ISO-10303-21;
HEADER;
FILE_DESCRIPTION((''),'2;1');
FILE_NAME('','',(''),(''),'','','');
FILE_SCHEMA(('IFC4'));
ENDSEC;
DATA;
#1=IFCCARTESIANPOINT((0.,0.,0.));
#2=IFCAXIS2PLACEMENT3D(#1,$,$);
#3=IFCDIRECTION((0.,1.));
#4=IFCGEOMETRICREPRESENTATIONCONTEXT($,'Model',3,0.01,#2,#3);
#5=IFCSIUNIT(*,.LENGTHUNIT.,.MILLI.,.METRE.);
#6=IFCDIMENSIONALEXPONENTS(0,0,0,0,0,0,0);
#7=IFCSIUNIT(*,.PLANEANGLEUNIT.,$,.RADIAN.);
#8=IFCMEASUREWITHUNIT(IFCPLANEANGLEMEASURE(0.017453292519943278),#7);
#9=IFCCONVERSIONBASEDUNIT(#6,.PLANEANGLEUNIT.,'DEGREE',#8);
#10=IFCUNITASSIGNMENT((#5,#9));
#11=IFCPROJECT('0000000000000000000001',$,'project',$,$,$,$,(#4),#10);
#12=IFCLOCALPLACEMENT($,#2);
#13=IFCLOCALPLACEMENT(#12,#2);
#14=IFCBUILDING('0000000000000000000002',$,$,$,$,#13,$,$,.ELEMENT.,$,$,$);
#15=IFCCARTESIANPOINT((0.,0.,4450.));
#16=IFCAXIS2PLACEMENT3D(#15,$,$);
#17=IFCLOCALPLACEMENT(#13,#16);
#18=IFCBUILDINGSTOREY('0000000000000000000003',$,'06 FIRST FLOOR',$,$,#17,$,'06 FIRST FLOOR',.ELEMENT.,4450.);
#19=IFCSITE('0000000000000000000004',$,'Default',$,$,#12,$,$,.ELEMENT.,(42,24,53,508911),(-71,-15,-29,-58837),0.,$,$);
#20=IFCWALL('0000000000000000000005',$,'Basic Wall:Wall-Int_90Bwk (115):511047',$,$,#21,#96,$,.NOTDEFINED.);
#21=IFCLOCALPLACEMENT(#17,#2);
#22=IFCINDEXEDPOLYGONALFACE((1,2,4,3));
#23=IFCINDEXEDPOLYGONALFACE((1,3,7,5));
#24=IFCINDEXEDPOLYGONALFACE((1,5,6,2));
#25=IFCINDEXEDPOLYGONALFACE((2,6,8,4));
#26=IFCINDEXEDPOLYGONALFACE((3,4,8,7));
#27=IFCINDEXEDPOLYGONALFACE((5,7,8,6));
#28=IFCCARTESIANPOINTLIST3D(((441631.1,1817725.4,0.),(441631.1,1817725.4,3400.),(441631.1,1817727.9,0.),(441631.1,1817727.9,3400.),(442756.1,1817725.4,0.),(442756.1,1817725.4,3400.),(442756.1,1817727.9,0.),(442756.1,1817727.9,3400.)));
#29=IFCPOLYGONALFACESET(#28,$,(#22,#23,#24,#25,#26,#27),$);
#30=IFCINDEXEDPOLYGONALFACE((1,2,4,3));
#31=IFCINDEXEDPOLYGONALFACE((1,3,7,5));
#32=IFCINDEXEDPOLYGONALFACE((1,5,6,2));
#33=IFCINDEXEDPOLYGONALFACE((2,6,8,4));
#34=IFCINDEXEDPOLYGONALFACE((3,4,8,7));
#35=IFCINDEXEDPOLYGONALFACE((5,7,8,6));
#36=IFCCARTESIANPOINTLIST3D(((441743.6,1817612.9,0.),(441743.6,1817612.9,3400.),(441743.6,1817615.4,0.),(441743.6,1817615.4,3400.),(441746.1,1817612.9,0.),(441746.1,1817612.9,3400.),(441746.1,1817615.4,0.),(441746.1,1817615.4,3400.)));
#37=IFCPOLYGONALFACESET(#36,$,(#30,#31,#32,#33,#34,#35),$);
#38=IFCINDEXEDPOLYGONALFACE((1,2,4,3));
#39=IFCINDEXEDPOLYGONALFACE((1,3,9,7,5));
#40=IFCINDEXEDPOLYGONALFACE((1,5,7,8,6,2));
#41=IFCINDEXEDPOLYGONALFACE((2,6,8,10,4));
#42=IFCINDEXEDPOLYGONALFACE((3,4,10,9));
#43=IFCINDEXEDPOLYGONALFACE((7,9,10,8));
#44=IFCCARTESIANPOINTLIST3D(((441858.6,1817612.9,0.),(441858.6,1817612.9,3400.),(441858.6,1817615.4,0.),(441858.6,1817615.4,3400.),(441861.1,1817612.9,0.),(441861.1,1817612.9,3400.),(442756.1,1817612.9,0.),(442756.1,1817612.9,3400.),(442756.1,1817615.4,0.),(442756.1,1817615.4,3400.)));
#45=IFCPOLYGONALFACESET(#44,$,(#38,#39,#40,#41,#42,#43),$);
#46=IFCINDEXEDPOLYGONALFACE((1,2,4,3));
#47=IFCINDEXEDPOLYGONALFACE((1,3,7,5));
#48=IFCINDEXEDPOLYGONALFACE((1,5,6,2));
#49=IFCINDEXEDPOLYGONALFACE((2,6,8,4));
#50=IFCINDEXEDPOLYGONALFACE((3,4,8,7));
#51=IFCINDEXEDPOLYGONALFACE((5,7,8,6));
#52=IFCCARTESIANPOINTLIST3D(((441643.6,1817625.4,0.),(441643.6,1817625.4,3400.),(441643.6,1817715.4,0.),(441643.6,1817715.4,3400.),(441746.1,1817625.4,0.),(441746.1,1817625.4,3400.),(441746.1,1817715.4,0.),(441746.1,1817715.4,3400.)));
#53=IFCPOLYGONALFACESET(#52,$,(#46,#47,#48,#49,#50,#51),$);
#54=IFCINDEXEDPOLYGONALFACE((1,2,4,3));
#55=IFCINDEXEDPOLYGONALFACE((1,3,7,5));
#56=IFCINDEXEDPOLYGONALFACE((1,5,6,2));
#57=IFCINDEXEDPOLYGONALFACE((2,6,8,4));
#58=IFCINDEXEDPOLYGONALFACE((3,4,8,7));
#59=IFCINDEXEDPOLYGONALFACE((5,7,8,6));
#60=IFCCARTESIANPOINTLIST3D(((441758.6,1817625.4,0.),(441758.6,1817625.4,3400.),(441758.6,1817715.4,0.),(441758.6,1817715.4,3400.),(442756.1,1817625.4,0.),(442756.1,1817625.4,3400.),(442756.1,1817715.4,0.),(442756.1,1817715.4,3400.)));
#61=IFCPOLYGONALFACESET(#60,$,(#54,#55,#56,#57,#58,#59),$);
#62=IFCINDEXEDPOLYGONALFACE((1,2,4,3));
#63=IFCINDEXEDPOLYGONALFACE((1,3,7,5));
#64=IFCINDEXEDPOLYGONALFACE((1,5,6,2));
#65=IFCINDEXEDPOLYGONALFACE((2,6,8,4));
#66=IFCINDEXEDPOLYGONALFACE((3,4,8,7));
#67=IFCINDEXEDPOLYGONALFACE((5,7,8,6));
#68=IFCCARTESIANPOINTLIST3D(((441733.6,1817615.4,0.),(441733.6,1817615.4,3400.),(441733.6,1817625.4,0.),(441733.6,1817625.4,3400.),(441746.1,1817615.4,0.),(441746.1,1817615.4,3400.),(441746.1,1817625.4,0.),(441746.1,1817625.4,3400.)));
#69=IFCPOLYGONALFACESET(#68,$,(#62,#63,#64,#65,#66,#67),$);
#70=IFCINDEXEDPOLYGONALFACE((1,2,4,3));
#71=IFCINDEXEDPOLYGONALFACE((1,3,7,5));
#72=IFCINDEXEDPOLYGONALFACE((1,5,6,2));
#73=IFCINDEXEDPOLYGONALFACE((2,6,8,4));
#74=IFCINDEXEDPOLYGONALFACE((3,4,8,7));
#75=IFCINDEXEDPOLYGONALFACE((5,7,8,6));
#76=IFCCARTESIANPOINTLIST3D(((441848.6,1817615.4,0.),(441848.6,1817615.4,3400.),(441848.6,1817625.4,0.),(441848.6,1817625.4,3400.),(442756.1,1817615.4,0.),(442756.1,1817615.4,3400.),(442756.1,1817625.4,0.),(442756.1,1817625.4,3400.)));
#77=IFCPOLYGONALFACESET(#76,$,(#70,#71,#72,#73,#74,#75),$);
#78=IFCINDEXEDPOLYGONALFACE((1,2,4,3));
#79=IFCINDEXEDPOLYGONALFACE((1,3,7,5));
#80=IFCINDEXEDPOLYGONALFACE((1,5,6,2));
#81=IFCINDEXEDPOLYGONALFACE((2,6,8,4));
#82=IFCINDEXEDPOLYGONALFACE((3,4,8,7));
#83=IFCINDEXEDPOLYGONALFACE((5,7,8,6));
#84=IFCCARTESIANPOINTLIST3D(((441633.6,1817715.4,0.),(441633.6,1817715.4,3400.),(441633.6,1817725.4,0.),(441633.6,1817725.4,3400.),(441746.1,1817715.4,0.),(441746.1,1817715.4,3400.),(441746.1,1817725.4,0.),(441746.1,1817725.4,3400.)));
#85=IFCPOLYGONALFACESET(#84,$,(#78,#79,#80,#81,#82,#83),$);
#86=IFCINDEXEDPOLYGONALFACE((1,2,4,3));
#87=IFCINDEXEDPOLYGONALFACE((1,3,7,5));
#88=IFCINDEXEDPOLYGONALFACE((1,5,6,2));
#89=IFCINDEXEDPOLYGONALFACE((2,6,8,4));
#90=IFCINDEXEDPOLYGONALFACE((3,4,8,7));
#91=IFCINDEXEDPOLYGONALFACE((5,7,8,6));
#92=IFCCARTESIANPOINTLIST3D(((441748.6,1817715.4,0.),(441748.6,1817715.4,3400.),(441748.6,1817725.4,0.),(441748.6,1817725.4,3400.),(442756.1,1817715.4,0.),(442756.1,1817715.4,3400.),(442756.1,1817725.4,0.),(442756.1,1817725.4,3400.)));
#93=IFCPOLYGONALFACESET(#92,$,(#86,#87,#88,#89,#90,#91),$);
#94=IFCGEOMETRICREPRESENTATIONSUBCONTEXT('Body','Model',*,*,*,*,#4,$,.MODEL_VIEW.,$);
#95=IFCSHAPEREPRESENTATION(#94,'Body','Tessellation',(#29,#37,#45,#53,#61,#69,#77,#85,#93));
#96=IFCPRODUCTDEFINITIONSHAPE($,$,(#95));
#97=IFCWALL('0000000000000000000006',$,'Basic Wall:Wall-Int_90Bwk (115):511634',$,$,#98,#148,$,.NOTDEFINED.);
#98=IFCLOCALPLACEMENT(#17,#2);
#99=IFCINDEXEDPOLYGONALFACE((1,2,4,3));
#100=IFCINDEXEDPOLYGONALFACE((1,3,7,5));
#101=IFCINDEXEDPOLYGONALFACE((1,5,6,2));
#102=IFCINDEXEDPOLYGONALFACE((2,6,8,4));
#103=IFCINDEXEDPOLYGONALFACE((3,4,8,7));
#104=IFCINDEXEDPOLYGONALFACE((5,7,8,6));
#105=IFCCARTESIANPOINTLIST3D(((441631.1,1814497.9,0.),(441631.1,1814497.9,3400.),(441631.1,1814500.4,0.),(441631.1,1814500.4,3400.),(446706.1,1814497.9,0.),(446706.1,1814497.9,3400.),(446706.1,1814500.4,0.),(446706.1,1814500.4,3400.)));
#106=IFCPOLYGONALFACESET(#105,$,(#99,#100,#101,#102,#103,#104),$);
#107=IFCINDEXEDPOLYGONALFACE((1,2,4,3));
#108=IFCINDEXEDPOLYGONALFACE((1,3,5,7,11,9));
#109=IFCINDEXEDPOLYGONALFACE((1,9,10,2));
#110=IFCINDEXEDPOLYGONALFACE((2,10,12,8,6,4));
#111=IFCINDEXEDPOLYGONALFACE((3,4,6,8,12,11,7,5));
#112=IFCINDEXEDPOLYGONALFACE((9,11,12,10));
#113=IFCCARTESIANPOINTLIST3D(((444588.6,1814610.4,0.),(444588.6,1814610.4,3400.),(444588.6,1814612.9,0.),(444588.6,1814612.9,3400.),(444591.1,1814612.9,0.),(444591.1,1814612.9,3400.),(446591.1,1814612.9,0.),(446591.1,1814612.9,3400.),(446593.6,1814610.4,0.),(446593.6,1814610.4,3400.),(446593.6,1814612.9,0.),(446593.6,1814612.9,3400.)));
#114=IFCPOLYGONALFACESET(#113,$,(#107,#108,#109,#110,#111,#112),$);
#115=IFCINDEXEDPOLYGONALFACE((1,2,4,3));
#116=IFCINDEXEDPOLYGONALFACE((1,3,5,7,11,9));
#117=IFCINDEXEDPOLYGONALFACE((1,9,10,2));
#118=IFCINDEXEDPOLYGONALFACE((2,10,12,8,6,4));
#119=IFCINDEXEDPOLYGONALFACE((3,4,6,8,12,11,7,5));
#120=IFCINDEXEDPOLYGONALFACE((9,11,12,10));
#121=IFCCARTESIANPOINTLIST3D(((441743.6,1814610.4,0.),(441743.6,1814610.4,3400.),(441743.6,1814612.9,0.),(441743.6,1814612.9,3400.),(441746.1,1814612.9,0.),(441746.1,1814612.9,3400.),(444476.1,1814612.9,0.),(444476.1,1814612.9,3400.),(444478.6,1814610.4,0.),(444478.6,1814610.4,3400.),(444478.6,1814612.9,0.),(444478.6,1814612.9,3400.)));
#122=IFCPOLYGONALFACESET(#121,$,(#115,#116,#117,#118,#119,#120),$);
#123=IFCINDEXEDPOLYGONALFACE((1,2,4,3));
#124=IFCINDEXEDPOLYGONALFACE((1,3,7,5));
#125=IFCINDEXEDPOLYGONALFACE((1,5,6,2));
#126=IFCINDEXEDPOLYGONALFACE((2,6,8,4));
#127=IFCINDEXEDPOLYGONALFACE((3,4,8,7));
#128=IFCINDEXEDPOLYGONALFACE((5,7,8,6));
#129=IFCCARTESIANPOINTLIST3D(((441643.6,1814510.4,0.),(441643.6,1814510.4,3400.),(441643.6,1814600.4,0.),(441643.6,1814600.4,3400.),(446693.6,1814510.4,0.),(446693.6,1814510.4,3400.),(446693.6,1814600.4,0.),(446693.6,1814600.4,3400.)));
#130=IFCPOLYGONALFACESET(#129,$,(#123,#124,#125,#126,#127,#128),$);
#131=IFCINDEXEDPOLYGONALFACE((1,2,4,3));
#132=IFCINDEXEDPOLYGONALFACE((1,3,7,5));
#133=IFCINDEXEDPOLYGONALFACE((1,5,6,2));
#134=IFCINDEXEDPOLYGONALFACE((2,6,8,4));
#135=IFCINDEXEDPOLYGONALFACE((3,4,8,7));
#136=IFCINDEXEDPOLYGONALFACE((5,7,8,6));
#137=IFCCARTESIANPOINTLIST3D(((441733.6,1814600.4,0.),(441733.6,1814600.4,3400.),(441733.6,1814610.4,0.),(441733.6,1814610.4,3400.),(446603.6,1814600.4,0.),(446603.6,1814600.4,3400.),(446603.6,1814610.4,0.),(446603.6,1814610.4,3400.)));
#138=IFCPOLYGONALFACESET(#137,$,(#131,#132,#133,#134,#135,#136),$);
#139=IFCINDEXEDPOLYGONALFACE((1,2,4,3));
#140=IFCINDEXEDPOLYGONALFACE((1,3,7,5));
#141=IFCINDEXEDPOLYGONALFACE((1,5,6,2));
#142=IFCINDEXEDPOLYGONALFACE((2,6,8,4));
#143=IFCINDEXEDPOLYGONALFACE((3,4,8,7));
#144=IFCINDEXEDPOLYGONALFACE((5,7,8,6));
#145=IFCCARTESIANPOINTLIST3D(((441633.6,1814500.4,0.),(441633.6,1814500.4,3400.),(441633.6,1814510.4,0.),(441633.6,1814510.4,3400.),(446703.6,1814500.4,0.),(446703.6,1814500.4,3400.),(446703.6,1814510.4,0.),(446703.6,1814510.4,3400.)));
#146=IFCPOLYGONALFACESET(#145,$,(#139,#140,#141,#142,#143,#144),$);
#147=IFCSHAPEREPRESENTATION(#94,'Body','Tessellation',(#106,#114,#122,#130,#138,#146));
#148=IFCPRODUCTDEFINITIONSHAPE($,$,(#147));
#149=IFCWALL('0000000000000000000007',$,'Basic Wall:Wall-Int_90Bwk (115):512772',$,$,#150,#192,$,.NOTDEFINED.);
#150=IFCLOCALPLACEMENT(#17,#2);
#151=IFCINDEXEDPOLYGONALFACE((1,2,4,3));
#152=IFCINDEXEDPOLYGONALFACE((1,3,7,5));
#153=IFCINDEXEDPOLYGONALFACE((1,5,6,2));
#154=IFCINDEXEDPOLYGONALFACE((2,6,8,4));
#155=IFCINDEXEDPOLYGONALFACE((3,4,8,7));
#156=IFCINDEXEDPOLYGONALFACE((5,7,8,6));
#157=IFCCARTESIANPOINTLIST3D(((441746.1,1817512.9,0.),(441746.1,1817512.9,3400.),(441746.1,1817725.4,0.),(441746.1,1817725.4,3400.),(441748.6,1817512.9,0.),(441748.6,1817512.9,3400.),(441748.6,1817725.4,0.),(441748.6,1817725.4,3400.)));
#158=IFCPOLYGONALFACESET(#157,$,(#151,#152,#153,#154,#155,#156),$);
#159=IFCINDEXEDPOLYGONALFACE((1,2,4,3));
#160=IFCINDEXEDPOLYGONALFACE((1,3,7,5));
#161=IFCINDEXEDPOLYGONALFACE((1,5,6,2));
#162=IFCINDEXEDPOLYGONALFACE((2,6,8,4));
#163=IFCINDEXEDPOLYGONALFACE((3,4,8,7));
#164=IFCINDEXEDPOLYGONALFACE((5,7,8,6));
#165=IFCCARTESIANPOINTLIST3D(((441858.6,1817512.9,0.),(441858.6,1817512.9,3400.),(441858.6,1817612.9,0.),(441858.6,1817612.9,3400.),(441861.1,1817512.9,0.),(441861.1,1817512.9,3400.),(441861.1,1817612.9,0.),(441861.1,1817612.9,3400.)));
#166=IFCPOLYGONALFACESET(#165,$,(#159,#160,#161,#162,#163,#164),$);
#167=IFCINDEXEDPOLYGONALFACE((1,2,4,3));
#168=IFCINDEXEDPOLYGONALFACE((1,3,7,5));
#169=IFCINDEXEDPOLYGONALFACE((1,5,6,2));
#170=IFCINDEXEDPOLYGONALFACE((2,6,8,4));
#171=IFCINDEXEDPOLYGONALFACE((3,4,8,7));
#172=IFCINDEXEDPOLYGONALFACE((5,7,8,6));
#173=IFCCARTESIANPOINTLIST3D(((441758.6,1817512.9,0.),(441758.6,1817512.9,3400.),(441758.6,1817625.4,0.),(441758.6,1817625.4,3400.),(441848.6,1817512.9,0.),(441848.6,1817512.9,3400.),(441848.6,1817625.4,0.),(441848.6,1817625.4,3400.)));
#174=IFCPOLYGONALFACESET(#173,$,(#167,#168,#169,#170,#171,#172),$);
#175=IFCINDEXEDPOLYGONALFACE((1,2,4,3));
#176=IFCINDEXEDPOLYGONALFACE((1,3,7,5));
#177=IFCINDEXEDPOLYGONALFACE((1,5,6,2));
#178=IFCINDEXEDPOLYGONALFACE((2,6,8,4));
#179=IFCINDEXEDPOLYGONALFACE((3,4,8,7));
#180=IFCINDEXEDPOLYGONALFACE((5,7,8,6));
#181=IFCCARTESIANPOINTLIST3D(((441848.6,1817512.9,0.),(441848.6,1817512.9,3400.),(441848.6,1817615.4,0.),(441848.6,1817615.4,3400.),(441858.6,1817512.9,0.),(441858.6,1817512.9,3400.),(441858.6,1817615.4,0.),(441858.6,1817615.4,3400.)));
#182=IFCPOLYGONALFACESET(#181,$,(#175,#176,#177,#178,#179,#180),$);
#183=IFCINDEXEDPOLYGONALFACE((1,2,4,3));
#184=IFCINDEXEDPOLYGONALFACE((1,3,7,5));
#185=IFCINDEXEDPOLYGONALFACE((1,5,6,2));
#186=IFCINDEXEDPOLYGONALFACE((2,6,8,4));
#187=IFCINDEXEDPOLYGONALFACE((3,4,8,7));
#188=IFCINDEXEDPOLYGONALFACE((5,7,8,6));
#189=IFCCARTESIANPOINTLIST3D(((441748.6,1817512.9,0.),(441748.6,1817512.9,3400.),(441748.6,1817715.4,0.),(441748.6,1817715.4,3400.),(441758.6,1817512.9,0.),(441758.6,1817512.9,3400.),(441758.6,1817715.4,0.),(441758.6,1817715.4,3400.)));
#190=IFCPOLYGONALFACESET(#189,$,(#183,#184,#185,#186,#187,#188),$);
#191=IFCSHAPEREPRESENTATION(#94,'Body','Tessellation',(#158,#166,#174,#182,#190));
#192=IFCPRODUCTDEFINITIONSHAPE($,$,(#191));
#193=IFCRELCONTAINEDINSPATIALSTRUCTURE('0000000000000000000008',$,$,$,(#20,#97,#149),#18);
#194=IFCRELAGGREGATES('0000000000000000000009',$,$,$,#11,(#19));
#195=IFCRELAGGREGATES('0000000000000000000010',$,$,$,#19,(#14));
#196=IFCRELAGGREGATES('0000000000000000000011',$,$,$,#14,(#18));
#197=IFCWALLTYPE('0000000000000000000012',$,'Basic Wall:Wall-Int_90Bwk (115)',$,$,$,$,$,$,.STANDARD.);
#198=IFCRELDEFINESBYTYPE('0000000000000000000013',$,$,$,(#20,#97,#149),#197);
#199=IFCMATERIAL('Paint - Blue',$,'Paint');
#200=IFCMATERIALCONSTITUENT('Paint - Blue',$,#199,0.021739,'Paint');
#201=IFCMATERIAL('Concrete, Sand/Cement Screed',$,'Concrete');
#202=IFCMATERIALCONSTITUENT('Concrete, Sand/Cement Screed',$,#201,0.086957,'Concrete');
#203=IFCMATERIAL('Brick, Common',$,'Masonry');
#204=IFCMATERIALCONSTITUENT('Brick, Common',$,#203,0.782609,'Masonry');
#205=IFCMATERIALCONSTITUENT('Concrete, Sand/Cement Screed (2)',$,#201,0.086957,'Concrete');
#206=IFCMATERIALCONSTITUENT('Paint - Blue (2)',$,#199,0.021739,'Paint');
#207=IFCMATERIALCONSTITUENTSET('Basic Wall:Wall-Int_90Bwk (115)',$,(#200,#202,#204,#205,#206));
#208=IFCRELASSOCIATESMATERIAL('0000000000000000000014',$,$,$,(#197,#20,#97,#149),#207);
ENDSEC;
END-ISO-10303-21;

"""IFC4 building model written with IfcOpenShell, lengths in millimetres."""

from ifc_helpers import new_model, entity, si_unit, converted_unit, direction, frame, origin, place, context, subcontext, project, spatial, indexed_curve, outline, extrude, material, constituent, constituent_set, type_object, element, save


model = new_model("IFC4")

# Units and contexts
model_context = context("Model", 3, precision=0.01, world=origin(), true_north=direction((0.0, 1.0)))
body_context = subcontext(model_context, "Body", "Model", "MODEL_VIEW")
ifc_project = project(units=[si_unit("LENGTHUNIT", "METRE", prefix="MILLI"), converted_unit("PLANEANGLEUNIT", "DEGREE", entity("IfcPlaneAngleMeasure", 0.017453292519943278), si_unit("PLANEANGLEUNIT", "RADIAN"), dimensions=[0, 0, 0, 0, 0, 0, 0])], contexts=[model_context])

# Site, building, storey
site_placement = place(None, origin())
site = spatial("IfcSite", under=ifc_project, at=site_placement, Name="Default", CompositionType="ELEMENT", RefLatitude=(42, 24, 53, 508911), RefLongitude=(-71, -15, -29, -58837), RefElevation=0.0)
building_placement = place(site_placement, origin())
building = spatial("IfcBuilding", under=site, at=building_placement, CompositionType="ELEMENT")
storey_placement = place(building_placement, frame((0.0, 0.0, 4450.0)))
storey = spatial("IfcBuildingStorey", under=building, at=storey_placement, Name="06 FIRST FLOOR", LongName="06 FIRST FLOOR", CompositionType="ELEMENT", Elevation=4450.0)

# Walls
ifc_material_1 = material(Name="Paint - Blue", Category="Paint")
ifc_constituent_1 = constituent(ifc_material_1, Name="Paint - Blue", Category="Paint", fraction=0.021739)
ifc_material_2 = material(Name="Concrete, Sand/Cement Screed", Category="Concrete")
ifc_constituent_2 = constituent(ifc_material_2, Name="Concrete, Sand/Cement Screed", Category="Concrete", fraction=0.086957)
ifc_material_3 = material(Name="Brick, Common", Category="Masonry")
ifc_constituent_3 = constituent(ifc_material_3, Name="Brick, Common", Category="Masonry", fraction=0.782609)
ifc_constituent_4 = constituent(ifc_material_2, Name="Concrete, Sand/Cement Screed (2)", Category="Concrete", fraction=0.086957)
ifc_constituent_5 = constituent(ifc_material_1, Name="Paint - Blue (2)", Category="Paint", fraction=0.021739)
ifc_constituent_set_1 = constituent_set(constituents=[ifc_constituent_1, ifc_constituent_2, ifc_constituent_3, ifc_constituent_4, ifc_constituent_5], Name="Basic Wall:Wall-Int_90Bwk (115)")
wall_type_1 = type_object("IfcWallType", Name="Basic Wall:Wall-Int_90Bwk (115)", PredefinedType="STANDARD", material=ifc_constituent_set_1)
wall_1_placement = place(storey_placement, frame((442756.1, 1817670.4, 0.0), z_axis=(0.0, 0.0, 1.0), x_axis=(-1.0, 0.0, 0.0)))
element("IfcWall", 1, at=wall_1_placement, inside=storey, type_object=wall_type_1, material=ifc_constituent_set_1, Name="Basic Wall:Wall-Int_90Bwk (115):511047", PredefinedType="NOTDEFINED", context=body_context, shape_type="SweptSolid", body=[
    extrude(outline(indexed_curve([(-1.2, -562.5), (1.3, -562.5), (1.3, 562.5), (-1.2, 562.5), (-1.2, -562.5)], self_intersect=False)), frame((562.5, -56.3, 0.0), z_axis=(0.0, 0.0, 1.0), x_axis=(0.0, 1.0, 0.0)), (0.0, 0.0, 1.0), 3400.0),
    extrude(outline(indexed_curve([(-1.3, -1.3), (1.3, -1.2), (1.3, 1.2), (-1.3, 1.2), (-1.3, -1.3)], self_intersect=False)), frame((1011.2, 56.3, 0.0), z_axis=(0.0, 0.0, 1.0), x_axis=(0.0, -1.0, 0.0)), (0.0, 0.0, 1.0), 3400.0),
    extrude(outline(indexed_curve([(-538.0, -1.5), (359.5, -1.5), (359.5, 1.0), (357.0, 1.0), (-538.0, 1.0), (-538.0, -1.5)], self_intersect=False)), frame((538.0, 56.5, 0.0)), (0.0, 0.0, 1.0), 3400.0),
    extrude(outline(indexed_curve([(-51.2, -45.0), (51.2, -45.0), (51.2, 45.0), (-51.2, 45.0), (-51.2, -45.0)], self_intersect=False)), frame((1061.2, 0.0, 0.0), z_axis=(0.0, 0.0, 1.0), x_axis=(-1.0, 0.0, 0.0)), (0.0, 0.0, 1.0), 3400.0),
    extrude(outline(indexed_curve([(-498.7, -45.0), (498.7, -45.0), (498.7, 45.0), (-498.7, 45.0), (-498.7, -45.0)], self_intersect=False)), frame((498.7, 0.0, 0.0)), (0.0, 0.0, 1.0), 3400.0),
    extrude(outline(indexed_curve([(-6.2, -5.0), (6.2, -5.0), (6.2, 5.0), (-6.2, 5.0), (-6.2, -5.0)], self_intersect=False)), frame((1016.2, 50.0, 0.0), z_axis=(0.0, 0.0, 1.0), x_axis=(-1.0, 0.0, 0.0)), (0.0, 0.0, 1.0), 3400.0),
    extrude(outline(indexed_curve([(-453.7, -5.0), (453.7, -5.0), (453.7, 5.0), (-453.7, 5.0), (-453.7, -5.0)], self_intersect=False)), frame((453.7, 50.0, 0.0)), (0.0, 0.0, 1.0), 3400.0),
    extrude(outline(indexed_curve([(-56.2, -5.0), (56.2, -5.0), (56.2, 5.0), (-56.2, 5.0), (-56.2, -5.0)], self_intersect=False)), frame((1066.2, -50.0, 0.0), z_axis=(0.0, 0.0, 1.0), x_axis=(-1.0, 0.0, 0.0)), (0.0, 0.0, 1.0), 3400.0),
    extrude(outline(indexed_curve([(-503.7, -5.0), (503.7, -5.0), (503.7, 5.0), (-503.7, 5.0), (-503.7, -5.0)], self_intersect=False)), frame((503.7, -50.0, 0.0)), (0.0, 0.0, 1.0), 3400.0),
])
wall_2_placement = place(storey_placement, frame((441631.1, 1814555.4, 0.0)))
element("IfcWall", 2, at=wall_2_placement, inside=storey, type_object=wall_type_1, material=ifc_constituent_set_1, Name="Basic Wall:Wall-Int_90Bwk (115):511634", PredefinedType="NOTDEFINED", context=body_context, shape_type="SweptSolid", body=[
    extrude(outline(indexed_curve([(-1.3, -2537.5), (1.2, -2537.5), (1.2, 2537.5), (-1.3, 2537.5), (-1.3, -2537.5)], self_intersect=False)), frame((2537.5, -56.2, 0.0), z_axis=(0.0, 0.0, 1.0), x_axis=(0.0, 1.0, 0.0)), (0.0, 0.0, 1.0), 3400.0),
    extrude(outline(indexed_curve([(-1000.0, -0.8), (1000.0, -0.8), (1002.5, -0.8), (1002.5, 1.7), (-1002.5, 1.7), (-1002.5, -0.8), (-1000.0, -0.8)], self_intersect=False)), frame((3960.0, 56.7, 0.0), z_axis=(0.0, 0.0, 1.0), x_axis=(-1.0, 0.0, 0.0)), (0.0, 0.0, 1.0), 3400.0),
    extrude(outline(indexed_curve([(-0.8, -1367.5), (1.7, -1367.5), (1.7, 1367.5), (-0.8, 1367.5), (-0.8, 1365.0), (-0.8, -1365.0), (-0.8, -1367.5)], self_intersect=False)), frame((1480.0, 56.7, 0.0), z_axis=(0.0, 0.0, 1.0), x_axis=(0.0, -1.0, 0.0)), (0.0, 0.0, 1.0), 3400.0),
    extrude(outline(indexed_curve([(-2525.0, -45.0), (2525.0, -45.0), (2525.0, 45.0), (-2525.0, 45.0), (-2525.0, -45.0)], self_intersect=False)), frame((2537.5, 0.0, 0.0)), (0.0, 0.0, 1.0), 3400.0),
    extrude(outline(indexed_curve([(-2435.0, -5.0), (2435.0, -5.0), (2435.0, 5.0), (-2435.0, 5.0), (-2435.0, -5.0)], self_intersect=False)), frame((2537.5, 50.0, 0.0)), (0.0, 0.0, 1.0), 3400.0),
    extrude(outline(indexed_curve([(-2535.0, -5.0), (2535.0, -5.0), (2535.0, 5.0), (-2535.0, 5.0), (-2535.0, -5.0)], self_intersect=False)), frame((2537.5, -50.0, 0.0)), (0.0, 0.0, 1.0), 3400.0),
])

# Wall
wall_3_placement = place(storey_placement, frame((441803.6, 1817612.9, 0.0), z_axis=(0.0, 0.0, 1.0), x_axis=(0.0, -1.0, 0.0)))
element("IfcWall", 3, at=wall_3_placement, inside=storey, type_object=wall_type_1, material=ifc_constituent_set_1, Name="Basic Wall:Wall-Int_90Bwk (115):512772", PredefinedType="NOTDEFINED", context=body_context, shape_type="SweptSolid", body=[
    extrude(outline(indexed_curve([(-1.2, -106.2), (1.3, -106.2), (1.3, 106.2), (-1.2, 106.2), (-1.2, -106.2)], self_intersect=False)), frame((-6.3, -56.3, 0.0), z_axis=(0.0, 0.0, 1.0), x_axis=(0.0, 1.0, 0.0)), (0.0, 0.0, 1.0), 3400.0),
    extrude(outline(indexed_curve([(-1.2, -50.0), (1.3, -50.0), (1.3, 50.0), (-1.2, 50.0), (-1.2, -50.0)], self_intersect=False)), frame((50.0, 56.3, 0.0), z_axis=(0.0, 0.0, 1.0), x_axis=(0.0, -1.0, 0.0)), (0.0, 0.0, 1.0), 3400.0),
    extrude(outline(indexed_curve([(-56.2, -45.0), (56.2, -45.0), (56.2, 45.0), (-56.2, 45.0), (-56.2, -45.0)], self_intersect=False)), frame((43.7, 0.0, 0.0)), (0.0, 0.0, 1.0), 3400.0),
    extrude(outline(indexed_curve([(-51.2, -5.0), (51.2, -5.0), (51.2, 5.0), (-51.2, 5.0), (-51.2, -5.0)], self_intersect=False)), frame((48.7, 50.0, 0.0)), (0.0, 0.0, 1.0), 3400.0),
    extrude(outline(indexed_curve([(-101.2, -5.0), (101.2, -5.0), (101.2, 5.0), (-101.2, 5.0), (-101.2, -5.0)], self_intersect=False)), frame((-1.3, -50.0, 0.0)), (0.0, 0.0, 1.0), 3400.0),
])

save(model, "model.ifc")
